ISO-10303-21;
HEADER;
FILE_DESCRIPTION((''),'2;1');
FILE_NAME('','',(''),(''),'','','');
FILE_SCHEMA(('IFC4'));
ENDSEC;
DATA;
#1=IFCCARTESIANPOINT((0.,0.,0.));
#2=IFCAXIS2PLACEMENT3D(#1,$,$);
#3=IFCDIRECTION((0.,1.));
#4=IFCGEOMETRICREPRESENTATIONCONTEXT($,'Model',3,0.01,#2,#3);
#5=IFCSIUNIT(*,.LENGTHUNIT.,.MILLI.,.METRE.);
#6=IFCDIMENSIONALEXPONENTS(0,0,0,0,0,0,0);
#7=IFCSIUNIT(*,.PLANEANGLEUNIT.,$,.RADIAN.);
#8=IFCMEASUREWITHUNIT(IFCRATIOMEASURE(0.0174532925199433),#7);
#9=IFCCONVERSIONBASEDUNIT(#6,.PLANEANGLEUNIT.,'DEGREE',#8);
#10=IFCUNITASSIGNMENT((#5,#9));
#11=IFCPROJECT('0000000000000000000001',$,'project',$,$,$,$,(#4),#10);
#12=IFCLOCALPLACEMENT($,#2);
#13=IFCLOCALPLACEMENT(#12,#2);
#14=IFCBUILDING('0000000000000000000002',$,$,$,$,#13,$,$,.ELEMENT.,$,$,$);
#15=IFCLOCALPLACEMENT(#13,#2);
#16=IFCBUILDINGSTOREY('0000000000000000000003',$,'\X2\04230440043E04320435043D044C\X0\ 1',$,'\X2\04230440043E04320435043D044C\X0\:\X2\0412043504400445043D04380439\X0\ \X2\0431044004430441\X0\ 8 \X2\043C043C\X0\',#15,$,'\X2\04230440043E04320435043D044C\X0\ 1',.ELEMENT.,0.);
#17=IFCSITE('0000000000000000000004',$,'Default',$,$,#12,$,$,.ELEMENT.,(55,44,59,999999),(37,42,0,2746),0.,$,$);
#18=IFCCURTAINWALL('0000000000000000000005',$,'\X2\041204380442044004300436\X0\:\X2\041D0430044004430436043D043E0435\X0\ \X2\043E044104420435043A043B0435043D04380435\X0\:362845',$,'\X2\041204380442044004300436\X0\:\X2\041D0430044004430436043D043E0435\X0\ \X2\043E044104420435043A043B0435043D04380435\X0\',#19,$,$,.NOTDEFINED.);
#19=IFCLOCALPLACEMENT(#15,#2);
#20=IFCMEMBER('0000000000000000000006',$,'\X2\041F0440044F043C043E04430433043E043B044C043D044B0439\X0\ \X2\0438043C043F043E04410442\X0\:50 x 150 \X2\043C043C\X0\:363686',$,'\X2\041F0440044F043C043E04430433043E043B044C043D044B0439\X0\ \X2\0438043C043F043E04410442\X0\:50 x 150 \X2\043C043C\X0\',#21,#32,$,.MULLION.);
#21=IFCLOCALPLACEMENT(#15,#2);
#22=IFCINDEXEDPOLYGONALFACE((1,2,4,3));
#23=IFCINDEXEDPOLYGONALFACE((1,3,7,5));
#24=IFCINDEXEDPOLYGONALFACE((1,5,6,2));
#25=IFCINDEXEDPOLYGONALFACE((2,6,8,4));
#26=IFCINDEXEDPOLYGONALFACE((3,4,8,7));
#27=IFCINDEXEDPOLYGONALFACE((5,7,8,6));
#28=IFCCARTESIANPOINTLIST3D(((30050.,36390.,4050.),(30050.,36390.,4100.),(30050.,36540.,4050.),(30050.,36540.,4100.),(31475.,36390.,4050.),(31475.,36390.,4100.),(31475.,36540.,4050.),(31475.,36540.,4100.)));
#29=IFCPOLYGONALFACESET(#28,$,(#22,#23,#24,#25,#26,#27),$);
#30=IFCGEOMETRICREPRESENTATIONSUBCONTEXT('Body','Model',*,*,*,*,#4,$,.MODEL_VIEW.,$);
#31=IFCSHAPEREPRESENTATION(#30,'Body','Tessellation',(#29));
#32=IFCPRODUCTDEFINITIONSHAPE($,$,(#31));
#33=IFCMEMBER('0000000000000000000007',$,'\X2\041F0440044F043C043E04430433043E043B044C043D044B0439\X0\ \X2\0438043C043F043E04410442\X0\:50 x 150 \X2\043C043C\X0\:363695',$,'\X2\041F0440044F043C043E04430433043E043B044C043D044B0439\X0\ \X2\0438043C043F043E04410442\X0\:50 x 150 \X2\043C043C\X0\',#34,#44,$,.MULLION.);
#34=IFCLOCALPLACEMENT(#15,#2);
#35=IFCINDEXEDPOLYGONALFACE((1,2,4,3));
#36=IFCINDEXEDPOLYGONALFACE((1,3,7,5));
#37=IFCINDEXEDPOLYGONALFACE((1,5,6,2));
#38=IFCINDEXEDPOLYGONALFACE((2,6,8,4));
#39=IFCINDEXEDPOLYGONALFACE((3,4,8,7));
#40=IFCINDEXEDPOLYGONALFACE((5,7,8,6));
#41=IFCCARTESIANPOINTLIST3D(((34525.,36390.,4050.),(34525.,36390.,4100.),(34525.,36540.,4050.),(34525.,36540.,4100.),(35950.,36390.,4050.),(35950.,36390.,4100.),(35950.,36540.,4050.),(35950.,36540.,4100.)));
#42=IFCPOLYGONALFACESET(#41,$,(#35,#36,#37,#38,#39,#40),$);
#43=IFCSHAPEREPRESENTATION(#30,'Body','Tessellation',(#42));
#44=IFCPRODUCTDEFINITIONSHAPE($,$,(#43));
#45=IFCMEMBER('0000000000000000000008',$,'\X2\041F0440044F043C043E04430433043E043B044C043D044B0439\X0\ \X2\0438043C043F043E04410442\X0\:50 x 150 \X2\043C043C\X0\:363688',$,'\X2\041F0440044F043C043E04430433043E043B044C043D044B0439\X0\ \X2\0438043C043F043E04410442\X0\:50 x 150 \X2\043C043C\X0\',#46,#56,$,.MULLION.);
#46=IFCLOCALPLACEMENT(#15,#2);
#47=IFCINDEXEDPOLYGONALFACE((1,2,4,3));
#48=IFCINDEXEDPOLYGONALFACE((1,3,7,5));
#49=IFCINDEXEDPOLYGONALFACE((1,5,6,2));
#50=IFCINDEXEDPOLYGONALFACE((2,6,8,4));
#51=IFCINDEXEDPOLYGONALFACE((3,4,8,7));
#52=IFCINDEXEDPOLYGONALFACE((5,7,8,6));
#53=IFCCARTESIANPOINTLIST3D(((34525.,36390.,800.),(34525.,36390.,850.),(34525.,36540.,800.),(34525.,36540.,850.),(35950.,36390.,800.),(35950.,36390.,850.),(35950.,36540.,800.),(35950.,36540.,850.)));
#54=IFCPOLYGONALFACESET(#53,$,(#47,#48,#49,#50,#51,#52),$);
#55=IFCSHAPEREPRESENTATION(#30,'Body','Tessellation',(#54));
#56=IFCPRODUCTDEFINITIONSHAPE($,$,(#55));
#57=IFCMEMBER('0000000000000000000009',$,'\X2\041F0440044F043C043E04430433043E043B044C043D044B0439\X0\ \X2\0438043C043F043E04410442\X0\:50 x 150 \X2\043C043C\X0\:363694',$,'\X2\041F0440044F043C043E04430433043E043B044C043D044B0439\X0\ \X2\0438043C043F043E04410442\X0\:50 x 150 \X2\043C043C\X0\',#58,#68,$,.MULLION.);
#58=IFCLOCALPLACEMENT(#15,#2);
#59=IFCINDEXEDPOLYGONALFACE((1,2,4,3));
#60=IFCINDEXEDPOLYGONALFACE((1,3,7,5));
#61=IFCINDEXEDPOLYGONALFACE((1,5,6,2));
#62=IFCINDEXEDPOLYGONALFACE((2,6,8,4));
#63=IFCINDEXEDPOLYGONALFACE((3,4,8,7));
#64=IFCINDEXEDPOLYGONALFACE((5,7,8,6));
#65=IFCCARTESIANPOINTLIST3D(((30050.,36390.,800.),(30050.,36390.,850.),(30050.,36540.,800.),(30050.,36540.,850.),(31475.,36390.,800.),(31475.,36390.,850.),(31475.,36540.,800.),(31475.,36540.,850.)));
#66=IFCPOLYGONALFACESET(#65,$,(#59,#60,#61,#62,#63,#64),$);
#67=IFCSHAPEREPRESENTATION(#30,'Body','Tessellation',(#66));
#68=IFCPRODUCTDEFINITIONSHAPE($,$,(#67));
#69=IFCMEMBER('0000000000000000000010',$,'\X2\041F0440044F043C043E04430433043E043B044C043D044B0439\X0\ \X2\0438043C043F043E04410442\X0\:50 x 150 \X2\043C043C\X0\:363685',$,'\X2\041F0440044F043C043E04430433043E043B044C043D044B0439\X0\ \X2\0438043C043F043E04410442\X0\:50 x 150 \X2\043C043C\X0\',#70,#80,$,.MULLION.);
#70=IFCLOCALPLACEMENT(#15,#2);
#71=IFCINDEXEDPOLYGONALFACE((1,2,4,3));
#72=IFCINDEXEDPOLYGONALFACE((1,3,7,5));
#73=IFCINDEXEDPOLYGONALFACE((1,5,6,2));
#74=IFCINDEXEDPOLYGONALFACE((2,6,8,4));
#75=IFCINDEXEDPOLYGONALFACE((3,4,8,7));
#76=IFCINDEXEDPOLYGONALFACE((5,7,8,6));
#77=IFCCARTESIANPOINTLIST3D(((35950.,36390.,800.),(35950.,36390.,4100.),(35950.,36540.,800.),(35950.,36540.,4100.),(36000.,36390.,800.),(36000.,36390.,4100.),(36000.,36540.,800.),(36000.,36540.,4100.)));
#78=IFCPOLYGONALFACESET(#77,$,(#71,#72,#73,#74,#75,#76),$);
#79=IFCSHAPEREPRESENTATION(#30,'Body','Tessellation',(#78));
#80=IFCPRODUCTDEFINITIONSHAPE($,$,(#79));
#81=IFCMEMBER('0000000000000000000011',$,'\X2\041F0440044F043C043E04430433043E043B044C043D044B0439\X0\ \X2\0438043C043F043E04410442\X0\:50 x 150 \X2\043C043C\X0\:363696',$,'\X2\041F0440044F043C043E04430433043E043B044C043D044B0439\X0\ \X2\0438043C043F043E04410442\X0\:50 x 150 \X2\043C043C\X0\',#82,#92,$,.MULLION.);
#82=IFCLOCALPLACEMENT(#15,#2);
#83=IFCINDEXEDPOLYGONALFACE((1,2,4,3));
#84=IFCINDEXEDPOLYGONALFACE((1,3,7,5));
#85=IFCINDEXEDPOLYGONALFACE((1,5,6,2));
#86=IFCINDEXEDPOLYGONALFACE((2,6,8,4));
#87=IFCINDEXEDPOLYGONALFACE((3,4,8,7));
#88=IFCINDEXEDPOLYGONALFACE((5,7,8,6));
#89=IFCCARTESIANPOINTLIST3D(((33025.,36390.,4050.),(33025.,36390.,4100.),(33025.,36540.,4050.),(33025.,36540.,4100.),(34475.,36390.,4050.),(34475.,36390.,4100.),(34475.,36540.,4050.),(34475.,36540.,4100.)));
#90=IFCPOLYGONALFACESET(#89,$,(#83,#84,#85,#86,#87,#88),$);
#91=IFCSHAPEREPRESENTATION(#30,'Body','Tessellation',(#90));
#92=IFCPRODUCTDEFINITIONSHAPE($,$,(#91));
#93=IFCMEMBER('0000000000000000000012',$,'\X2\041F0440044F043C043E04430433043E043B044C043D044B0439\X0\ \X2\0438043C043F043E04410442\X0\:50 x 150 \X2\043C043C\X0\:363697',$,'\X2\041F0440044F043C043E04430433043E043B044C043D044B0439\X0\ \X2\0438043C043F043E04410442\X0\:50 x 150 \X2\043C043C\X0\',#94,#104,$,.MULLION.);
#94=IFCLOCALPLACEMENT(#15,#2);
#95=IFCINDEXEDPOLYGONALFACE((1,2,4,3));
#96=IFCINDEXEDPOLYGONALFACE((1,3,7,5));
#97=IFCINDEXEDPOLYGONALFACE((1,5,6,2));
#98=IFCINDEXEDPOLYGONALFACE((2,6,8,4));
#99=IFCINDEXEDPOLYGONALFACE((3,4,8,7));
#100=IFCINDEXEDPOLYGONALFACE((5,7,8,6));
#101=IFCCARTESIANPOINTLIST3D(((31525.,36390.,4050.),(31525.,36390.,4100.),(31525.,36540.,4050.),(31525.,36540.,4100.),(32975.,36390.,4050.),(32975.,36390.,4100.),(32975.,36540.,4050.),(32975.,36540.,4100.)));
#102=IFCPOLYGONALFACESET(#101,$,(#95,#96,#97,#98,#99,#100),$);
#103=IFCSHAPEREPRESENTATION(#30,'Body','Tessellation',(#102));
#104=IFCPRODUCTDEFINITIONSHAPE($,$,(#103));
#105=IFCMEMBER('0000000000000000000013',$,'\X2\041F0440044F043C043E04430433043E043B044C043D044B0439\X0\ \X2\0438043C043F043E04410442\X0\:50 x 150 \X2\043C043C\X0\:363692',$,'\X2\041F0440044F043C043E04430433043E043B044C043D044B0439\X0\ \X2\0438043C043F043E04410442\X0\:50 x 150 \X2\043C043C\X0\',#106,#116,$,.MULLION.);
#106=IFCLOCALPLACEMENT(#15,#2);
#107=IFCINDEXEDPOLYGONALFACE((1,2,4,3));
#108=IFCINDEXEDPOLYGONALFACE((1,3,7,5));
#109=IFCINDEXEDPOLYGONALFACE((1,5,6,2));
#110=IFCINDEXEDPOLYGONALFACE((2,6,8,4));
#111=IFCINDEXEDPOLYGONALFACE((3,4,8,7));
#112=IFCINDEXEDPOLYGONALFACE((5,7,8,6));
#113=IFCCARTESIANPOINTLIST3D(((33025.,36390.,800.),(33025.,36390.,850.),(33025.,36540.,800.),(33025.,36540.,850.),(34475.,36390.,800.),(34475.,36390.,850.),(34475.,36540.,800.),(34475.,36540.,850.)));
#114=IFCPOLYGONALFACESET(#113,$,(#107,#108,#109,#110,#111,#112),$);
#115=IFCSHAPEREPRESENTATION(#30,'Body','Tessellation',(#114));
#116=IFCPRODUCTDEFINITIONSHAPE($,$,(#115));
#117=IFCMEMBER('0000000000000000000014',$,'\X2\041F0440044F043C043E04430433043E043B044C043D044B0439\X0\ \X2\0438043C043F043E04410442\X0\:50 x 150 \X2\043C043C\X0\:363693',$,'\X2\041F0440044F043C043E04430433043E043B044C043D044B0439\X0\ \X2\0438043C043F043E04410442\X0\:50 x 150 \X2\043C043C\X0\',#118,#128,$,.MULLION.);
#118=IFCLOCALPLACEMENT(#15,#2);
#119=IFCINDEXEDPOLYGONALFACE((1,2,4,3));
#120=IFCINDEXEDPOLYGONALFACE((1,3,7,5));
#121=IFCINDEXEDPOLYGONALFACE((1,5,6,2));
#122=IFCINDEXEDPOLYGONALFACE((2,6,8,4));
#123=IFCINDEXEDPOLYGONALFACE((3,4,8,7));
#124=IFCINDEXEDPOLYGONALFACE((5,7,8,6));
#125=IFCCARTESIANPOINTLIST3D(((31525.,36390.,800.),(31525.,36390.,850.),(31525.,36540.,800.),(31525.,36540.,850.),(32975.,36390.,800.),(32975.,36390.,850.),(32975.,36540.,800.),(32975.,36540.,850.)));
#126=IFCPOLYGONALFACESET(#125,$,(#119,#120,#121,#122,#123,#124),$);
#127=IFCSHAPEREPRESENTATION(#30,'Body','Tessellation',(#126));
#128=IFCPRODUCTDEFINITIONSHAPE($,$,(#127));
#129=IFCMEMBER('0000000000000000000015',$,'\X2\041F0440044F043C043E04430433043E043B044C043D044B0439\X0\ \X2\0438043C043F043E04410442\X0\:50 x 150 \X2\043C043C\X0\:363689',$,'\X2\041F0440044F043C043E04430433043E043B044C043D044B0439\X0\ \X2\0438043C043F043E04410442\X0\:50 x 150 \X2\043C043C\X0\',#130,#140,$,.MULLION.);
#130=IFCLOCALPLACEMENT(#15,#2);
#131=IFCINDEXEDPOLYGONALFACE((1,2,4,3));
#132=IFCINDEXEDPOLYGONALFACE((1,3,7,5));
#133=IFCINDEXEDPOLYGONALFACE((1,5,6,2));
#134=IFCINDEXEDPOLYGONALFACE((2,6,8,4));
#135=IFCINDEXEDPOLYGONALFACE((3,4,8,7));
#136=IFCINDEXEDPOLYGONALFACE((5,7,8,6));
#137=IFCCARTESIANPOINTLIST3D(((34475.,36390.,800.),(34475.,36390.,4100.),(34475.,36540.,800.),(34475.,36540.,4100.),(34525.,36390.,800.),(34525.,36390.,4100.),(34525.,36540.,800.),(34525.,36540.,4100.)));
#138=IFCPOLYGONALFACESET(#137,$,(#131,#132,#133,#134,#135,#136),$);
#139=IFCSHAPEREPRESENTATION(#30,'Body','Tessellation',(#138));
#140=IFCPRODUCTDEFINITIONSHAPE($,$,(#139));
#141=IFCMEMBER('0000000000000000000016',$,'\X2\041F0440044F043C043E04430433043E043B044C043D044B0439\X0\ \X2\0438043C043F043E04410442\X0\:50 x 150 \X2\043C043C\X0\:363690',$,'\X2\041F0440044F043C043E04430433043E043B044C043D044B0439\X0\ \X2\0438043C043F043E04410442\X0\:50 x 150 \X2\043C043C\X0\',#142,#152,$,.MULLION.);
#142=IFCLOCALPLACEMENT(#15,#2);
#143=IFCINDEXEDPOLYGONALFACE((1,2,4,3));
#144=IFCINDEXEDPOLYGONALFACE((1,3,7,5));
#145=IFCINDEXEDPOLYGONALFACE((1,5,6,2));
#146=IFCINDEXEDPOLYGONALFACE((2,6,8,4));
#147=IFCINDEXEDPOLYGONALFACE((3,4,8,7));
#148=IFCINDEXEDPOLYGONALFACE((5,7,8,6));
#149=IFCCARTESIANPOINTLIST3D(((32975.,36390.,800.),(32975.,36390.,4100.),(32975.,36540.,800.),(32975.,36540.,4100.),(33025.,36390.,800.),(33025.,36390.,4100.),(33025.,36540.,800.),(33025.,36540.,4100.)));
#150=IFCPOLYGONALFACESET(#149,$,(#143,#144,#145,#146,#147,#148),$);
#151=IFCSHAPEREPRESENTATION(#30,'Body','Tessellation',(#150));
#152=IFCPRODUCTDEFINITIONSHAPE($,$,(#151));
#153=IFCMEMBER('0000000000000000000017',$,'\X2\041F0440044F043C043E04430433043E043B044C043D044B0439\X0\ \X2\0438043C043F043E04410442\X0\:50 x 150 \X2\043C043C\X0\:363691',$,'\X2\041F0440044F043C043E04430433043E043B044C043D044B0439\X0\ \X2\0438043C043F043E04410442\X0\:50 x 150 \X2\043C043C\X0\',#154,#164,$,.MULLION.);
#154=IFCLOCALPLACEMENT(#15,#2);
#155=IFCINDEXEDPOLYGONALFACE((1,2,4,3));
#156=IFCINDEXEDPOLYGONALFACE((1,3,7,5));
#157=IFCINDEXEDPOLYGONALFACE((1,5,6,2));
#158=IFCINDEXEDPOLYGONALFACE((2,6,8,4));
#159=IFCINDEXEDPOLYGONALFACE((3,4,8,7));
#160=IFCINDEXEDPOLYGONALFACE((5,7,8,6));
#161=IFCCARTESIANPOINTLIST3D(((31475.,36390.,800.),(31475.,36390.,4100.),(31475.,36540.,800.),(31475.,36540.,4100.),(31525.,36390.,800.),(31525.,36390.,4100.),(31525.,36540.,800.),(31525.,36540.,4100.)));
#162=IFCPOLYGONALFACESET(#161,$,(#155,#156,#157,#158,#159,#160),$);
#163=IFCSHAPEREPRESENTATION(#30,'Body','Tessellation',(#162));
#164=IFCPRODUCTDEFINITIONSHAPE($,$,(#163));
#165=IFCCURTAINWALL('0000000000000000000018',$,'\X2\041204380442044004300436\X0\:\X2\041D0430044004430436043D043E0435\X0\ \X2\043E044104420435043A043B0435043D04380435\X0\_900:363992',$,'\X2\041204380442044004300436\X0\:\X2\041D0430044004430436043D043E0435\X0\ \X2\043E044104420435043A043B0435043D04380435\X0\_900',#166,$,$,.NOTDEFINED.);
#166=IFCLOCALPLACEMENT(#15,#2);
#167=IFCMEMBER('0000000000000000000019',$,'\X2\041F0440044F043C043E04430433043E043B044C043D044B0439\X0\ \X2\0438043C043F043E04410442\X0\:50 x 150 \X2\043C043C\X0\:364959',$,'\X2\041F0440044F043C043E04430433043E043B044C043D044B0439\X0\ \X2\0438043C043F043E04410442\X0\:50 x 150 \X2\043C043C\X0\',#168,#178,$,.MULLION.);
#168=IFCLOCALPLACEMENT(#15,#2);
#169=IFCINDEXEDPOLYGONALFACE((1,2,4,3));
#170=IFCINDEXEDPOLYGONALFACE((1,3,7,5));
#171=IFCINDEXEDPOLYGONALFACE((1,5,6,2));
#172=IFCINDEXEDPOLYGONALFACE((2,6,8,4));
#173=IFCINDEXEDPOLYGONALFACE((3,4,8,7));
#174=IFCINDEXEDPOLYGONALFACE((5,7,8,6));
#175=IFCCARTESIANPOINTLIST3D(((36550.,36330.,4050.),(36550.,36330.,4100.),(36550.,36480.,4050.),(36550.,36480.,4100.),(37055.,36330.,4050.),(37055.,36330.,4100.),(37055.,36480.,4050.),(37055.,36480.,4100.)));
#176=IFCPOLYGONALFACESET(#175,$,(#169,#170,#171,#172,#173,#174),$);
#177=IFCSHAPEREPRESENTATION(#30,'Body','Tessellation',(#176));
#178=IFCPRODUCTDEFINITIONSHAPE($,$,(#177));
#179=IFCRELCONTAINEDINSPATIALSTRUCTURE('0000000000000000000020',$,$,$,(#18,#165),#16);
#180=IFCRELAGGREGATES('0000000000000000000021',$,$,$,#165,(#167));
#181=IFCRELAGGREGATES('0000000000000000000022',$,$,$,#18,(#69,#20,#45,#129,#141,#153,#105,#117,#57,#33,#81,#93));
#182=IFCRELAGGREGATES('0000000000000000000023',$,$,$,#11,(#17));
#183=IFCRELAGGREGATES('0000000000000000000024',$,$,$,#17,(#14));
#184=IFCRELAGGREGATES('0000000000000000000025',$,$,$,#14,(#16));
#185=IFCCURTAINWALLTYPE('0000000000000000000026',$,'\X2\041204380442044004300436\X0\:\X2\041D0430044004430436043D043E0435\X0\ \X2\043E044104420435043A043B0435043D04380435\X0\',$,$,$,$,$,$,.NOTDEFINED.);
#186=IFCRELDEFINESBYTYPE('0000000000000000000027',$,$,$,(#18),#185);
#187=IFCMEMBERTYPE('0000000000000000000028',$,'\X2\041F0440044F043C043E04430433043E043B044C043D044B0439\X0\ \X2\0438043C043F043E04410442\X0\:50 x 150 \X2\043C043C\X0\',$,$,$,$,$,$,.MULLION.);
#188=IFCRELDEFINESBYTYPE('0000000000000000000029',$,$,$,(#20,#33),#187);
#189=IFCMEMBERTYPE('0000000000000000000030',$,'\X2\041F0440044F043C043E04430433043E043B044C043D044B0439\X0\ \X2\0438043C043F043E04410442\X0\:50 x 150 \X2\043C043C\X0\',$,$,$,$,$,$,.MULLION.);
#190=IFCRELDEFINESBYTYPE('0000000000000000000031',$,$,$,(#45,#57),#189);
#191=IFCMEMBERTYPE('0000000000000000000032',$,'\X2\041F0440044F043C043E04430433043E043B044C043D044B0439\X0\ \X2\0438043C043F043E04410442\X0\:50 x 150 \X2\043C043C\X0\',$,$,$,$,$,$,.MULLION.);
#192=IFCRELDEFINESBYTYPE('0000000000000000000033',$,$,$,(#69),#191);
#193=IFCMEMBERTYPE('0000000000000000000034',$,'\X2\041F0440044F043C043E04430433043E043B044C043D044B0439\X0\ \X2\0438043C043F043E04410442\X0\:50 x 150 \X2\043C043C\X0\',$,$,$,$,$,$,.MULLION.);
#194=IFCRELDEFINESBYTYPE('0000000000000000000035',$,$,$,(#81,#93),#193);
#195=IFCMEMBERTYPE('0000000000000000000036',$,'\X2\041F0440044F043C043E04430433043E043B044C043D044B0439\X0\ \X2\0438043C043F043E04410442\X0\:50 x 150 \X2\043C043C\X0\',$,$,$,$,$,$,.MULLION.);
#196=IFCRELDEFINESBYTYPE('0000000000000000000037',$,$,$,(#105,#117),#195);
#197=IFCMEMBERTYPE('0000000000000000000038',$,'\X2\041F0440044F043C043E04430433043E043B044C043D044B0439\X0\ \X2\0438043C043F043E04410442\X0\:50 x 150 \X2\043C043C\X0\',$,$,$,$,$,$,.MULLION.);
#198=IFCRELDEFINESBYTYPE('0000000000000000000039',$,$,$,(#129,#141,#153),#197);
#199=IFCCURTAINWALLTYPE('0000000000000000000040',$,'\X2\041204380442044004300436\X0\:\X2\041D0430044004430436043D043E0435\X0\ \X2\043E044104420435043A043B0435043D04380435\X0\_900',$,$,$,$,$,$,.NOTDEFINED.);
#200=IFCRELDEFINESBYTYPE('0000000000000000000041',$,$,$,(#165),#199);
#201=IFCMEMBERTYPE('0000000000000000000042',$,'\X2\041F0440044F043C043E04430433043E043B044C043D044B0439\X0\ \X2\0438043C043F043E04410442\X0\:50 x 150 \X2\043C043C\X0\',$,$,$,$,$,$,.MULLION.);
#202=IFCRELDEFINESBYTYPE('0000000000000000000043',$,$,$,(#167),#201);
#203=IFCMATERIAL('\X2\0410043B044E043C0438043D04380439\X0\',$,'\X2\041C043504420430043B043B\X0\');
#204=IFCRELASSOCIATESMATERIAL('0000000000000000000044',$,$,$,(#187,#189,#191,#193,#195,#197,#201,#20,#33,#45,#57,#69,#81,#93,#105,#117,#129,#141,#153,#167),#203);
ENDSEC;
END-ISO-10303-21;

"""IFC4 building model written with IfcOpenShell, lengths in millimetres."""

from ifc_helpers import new_model, entity, si_unit, converted_unit, direction, frame, origin, origin_2d_with_axis, place, context, subcontext, project, spatial, rectangle, extrude, source, transform, mapped, material, material_profile, profile_set, profile_usage, type_object, type_shapes, element, aggregate, save


model = new_model("IFC4")

# Units and contexts
model_context = context("Model", 3, precision=0.01, world=origin(), true_north=direction((0.0, 1.0)))
body_context = subcontext(model_context, "Body", "Model", "MODEL_VIEW")
ifc_project = project(units=[si_unit("LENGTHUNIT", "METRE", prefix="MILLI"), converted_unit("PLANEANGLEUNIT", "DEGREE", entity("IfcRatioMeasure", 0.0174532925199433), si_unit("PLANEANGLEUNIT", "RADIAN"), dimensions=[0, 0, 0, 0, 0, 0, 0])], contexts=[model_context])

# Site, building, storey
site_placement = place(None, origin())
site = spatial("IfcSite", under=ifc_project, at=site_placement, Name="Default", CompositionType="ELEMENT", RefLatitude=(55, 44, 59, 999999), RefLongitude=(37, 42, 0, 2746), RefElevation=0.0)
building_placement = place(site_placement, origin())
building = spatial("IfcBuilding", under=site, at=building_placement, CompositionType="ELEMENT")
storey_placement = place(building_placement, origin())
storey = spatial("IfcBuildingStorey", under=building, at=storey_placement, Name="Уровень 1", ObjectType="Уровень:Верхний брус 8 мм", LongName="Уровень 1", CompositionType="ELEMENT", Elevation=0.0)

# Curtain walls, members
curtain_wall_type_1 = type_object("IfcCurtainWallType", Name="Витраж:Наружное остекление", PredefinedType="NOTDEFINED")
curtain_wall_1_placement = place(storey_placement, origin())
curtain_wall_1 = element("IfcCurtainWall", 1, at=curtain_wall_1_placement, inside=storey, type_object=curtain_wall_type_1, Name="Витраж:Наружное остекление:362845", ObjectType="Витраж:Наружное остекление", PredefinedType="NOTDEFINED")
ifc_material_1 = material(Name="Алюминий", Category="Металл")
ifc_material_profile = material_profile(ifc_material_1, rectangle(XDim=150.0, YDim=50.0, at=origin_2d_with_axis()), Name="50 x 150 мм")
ifc_profile_set = profile_set([ifc_material_profile], Name="50 x 150 мм")
ifc_profile_usage_1 = profile_usage(ifc_profile_set)
member_type_1 = type_object("IfcMemberType", Name="Прямоугольный импост:50 x 150 мм", PredefinedType="MULLION", material=ifc_profile_set)
shared_shape_1 = source(origin(), body_context, "Body", "SweptSolid", [
    extrude(rectangle(XDim=150.0, YDim=50.0, at=origin_2d_with_axis()), frame((-25.0, 0.0, -1425.0), z_axis=(0.0, 0.0, 1.0), x_axis=(0.0, -1.0, 0.0)), (0.0, 0.0, 1.0), 1425.0),
])
type_shapes(member_type_1, [shared_shape_1])
member_1_placement = place(storey_placement, frame((30050.0, 36465.0, 4100.0), z_axis=(-1.0, 0.0, 0.0), x_axis=(0.0, 0.0, 1.0)))
member_1 = element("IfcMember", 2, at=member_1_placement, type_object=member_type_1, material=ifc_profile_usage_1, Name="Прямоугольный импост:50 x 150 мм:363686", ObjectType="Прямоугольный импост:50 x 150 мм", PredefinedType="MULLION", context=body_context, shape_type="MappedRepresentation", body=[
    mapped(shared_shape_1, transform((0.0, 0.0, 0.0), scale=1.0)),
])
ifc_profile_usage_2 = profile_usage(ifc_profile_set)
member_2_placement = place(storey_placement, frame((34525.0, 36465.0, 4100.0), z_axis=(-1.0, 0.0, 0.0), x_axis=(0.0, 0.0, 1.0)))
member_2 = element("IfcMember", 3, at=member_2_placement, type_object=member_type_1, material=ifc_profile_usage_2, Name="Прямоугольный импост:50 x 150 мм:363695", ObjectType="Прямоугольный импост:50 x 150 мм", PredefinedType="MULLION", context=body_context, shape_type="MappedRepresentation", body=[
    mapped(shared_shape_1, transform((0.0, 0.0, 0.0), scale=1.0)),
])
ifc_profile_usage_3 = profile_usage(ifc_profile_set)
member_type_2 = type_object("IfcMemberType", Name="Прямоугольный импост:50 x 150 мм", PredefinedType="MULLION", material=ifc_profile_set)
shared_shape_2 = source(origin(), body_context, "Body", "SweptSolid", [
    extrude(rectangle(XDim=150.0, YDim=50.0, at=origin_2d_with_axis()), frame((-25.0, 0.0, -1425.0), z_axis=(0.0, 0.0, 1.0), x_axis=(0.0, -1.0, 0.0)), (0.0, 0.0, 1.0), 1425.0),
])
type_shapes(member_type_2, [shared_shape_2])
member_3_placement = place(storey_placement, frame((35950.0, 36465.0, 800.0), z_axis=(1.0, 0.0, 0.0), x_axis=(0.0, 0.0, -1.0)))
member_3 = element("IfcMember", 4, at=member_3_placement, type_object=member_type_2, material=ifc_profile_usage_3, Name="Прямоугольный импост:50 x 150 мм:363688", ObjectType="Прямоугольный импост:50 x 150 мм", PredefinedType="MULLION", context=body_context, shape_type="MappedRepresentation", body=[
    mapped(shared_shape_2, transform((0.0, 0.0, 0.0), scale=1.0)),
])
ifc_profile_usage_4 = profile_usage(ifc_profile_set)
member_4_placement = place(storey_placement, frame((31475.0, 36465.0, 800.0), z_axis=(1.0, 0.0, 0.0), x_axis=(0.0, 0.0, -1.0)))
member_4 = element("IfcMember", 5, at=member_4_placement, type_object=member_type_2, material=ifc_profile_usage_4, Name="Прямоугольный импост:50 x 150 мм:363694", ObjectType="Прямоугольный импост:50 x 150 мм", PredefinedType="MULLION", context=body_context, shape_type="MappedRepresentation", body=[
    mapped(shared_shape_2, transform((0.0, 0.0, 0.0), scale=1.0)),
])
ifc_profile_usage_5 = profile_usage(ifc_profile_set)
member_type_3 = type_object("IfcMemberType", Name="Прямоугольный импост:50 x 150 мм", PredefinedType="MULLION", material=ifc_profile_set)
shared_shape_3 = source(origin(), body_context, "Body", "SweptSolid", [
    extrude(rectangle(XDim=150.0, YDim=50.0, at=origin_2d_with_axis()), frame((-25.0, 0.0, -3300.0), z_axis=(0.0, 0.0, 1.0), x_axis=(0.0, -1.0, 0.0)), (0.0, 0.0, 1.0), 3300.0),
])
type_shapes(member_type_3, [shared_shape_3])
member_5_placement = place(storey_placement, frame((36000.0, 36465.0, 4100.0)))
member_5 = element("IfcMember", 6, at=member_5_placement, type_object=member_type_3, material=ifc_profile_usage_5, Name="Прямоугольный импост:50 x 150 мм:363685", ObjectType="Прямоугольный импост:50 x 150 мм", PredefinedType="MULLION", context=body_context, shape_type="MappedRepresentation", body=[
    mapped(shared_shape_3, transform((0.0, 0.0, 0.0), scale=1.0)),
])
ifc_profile_usage_6 = profile_usage(ifc_profile_set)
member_type_4 = type_object("IfcMemberType", Name="Прямоугольный импост:50 x 150 мм", PredefinedType="MULLION", material=ifc_profile_set)
shared_shape_4 = source(origin(), body_context, "Body", "SweptSolid", [
    extrude(rectangle(XDim=150.0, YDim=50.0, at=origin_2d_with_axis()), frame((-25.0, 0.0, -1450.0), z_axis=(0.0, 0.0, 1.0), x_axis=(0.0, -1.0, 0.0)), (0.0, 0.0, 1.0), 1450.0),
])
type_shapes(member_type_4, [shared_shape_4])
member_6_placement = place(storey_placement, frame((33025.0, 36465.0, 4100.0), z_axis=(-1.0, 0.0, 0.0), x_axis=(0.0, 0.0, 1.0)))
member_6 = element("IfcMember", 7, at=member_6_placement, type_object=member_type_4, material=ifc_profile_usage_6, Name="Прямоугольный импост:50 x 150 мм:363696", ObjectType="Прямоугольный импост:50 x 150 мм", PredefinedType="MULLION", context=body_context, shape_type="MappedRepresentation", body=[
    mapped(shared_shape_4, transform((0.0, 0.0, 0.0), scale=1.0)),
])
ifc_profile_usage_7 = profile_usage(ifc_profile_set)
member_7_placement = place(storey_placement, frame((31525.0, 36465.0, 4100.0), z_axis=(-1.0, 0.0, 0.0), x_axis=(0.0, 0.0, 1.0)))
member_7 = element("IfcMember", 8, at=member_7_placement, type_object=member_type_4, material=ifc_profile_usage_7, Name="Прямоугольный импост:50 x 150 мм:363697", ObjectType="Прямоугольный импост:50 x 150 мм", PredefinedType="MULLION", context=body_context, shape_type="MappedRepresentation", body=[
    mapped(shared_shape_4, transform((0.0, 0.0, 0.0), scale=1.0)),
])
ifc_profile_usage_8 = profile_usage(ifc_profile_set)
member_type_5 = type_object("IfcMemberType", Name="Прямоугольный импост:50 x 150 мм", PredefinedType="MULLION", material=ifc_profile_set)
shared_shape_5 = source(origin(), body_context, "Body", "SweptSolid", [
    extrude(rectangle(XDim=150.0, YDim=50.0, at=origin_2d_with_axis()), frame((-25.0, 0.0, -1450.0), z_axis=(0.0, 0.0, 1.0), x_axis=(0.0, -1.0, 0.0)), (0.0, 0.0, 1.0), 1450.0),
])
type_shapes(member_type_5, [shared_shape_5])
member_8_placement = place(storey_placement, frame((34475.0, 36465.0, 800.0), z_axis=(1.0, 0.0, 0.0), x_axis=(0.0, 0.0, -1.0)))
member_8 = element("IfcMember", 9, at=member_8_placement, type_object=member_type_5, material=ifc_profile_usage_8, Name="Прямоугольный импост:50 x 150 мм:363692", ObjectType="Прямоугольный импост:50 x 150 мм", PredefinedType="MULLION", context=body_context, shape_type="MappedRepresentation", body=[
    mapped(shared_shape_5, transform((0.0, 0.0, 0.0), scale=1.0)),
])
ifc_profile_usage_9 = profile_usage(ifc_profile_set)
member_9_placement = place(storey_placement, frame((32975.0, 36465.0, 800.0), z_axis=(1.0, 0.0, 0.0), x_axis=(0.0, 0.0, -1.0)))
member_9 = element("IfcMember", 10, at=member_9_placement, type_object=member_type_5, material=ifc_profile_usage_9, Name="Прямоугольный импост:50 x 150 мм:363693", ObjectType="Прямоугольный импост:50 x 150 мм", PredefinedType="MULLION", context=body_context, shape_type="MappedRepresentation", body=[
    mapped(shared_shape_5, transform((0.0, 0.0, 0.0), scale=1.0)),
])
ifc_profile_usage_10 = profile_usage(ifc_profile_set)
member_type_6 = type_object("IfcMemberType", Name="Прямоугольный импост:50 x 150 мм", PredefinedType="MULLION", material=ifc_profile_set)
shared_shape_6 = source(origin(), body_context, "Body", "SweptSolid", [
    extrude(rectangle(XDim=150.0, YDim=50.0, at=origin_2d_with_axis()), frame((0.0, 0.0, -3300.0), z_axis=(0.0, 0.0, 1.0), x_axis=(0.0, -1.0, 0.0)), (0.0, 0.0, 1.0), 3300.0),
])
type_shapes(member_type_6, [shared_shape_6])
member_10_placement = place(storey_placement, frame((34500.0, 36465.0, 800.0), z_axis=(0.0, 0.0, -1.0), x_axis=(-1.0, 0.0, 0.0)))
member_10 = element("IfcMember", 11, at=member_10_placement, type_object=member_type_6, material=ifc_profile_usage_10, Name="Прямоугольный импост:50 x 150 мм:363689", ObjectType="Прямоугольный импост:50 x 150 мм", PredefinedType="MULLION", context=body_context, shape_type="MappedRepresentation", body=[
    mapped(shared_shape_6, transform((0.0, 0.0, 0.0), scale=1.0)),
])
ifc_profile_usage_11 = profile_usage(ifc_profile_set)
member_11_placement = place(storey_placement, frame((33000.0, 36465.0, 800.0), z_axis=(0.0, 0.0, -1.0), x_axis=(-1.0, 0.0, 0.0)))
member_11 = element("IfcMember", 12, at=member_11_placement, type_object=member_type_6, material=ifc_profile_usage_11, Name="Прямоугольный импост:50 x 150 мм:363690", ObjectType="Прямоугольный импост:50 x 150 мм", PredefinedType="MULLION", context=body_context, shape_type="MappedRepresentation", body=[
    mapped(shared_shape_6, transform((0.0, 0.0, 0.0), scale=1.0)),
])
ifc_profile_usage_12 = profile_usage(ifc_profile_set)
member_12_placement = place(storey_placement, frame((31500.0, 36465.0, 800.0), z_axis=(0.0, 0.0, -1.0), x_axis=(-1.0, 0.0, 0.0)))
member_12 = element("IfcMember", 13, at=member_12_placement, type_object=member_type_6, material=ifc_profile_usage_12, Name="Прямоугольный импост:50 x 150 мм:363691", ObjectType="Прямоугольный импост:50 x 150 мм", PredefinedType="MULLION", context=body_context, shape_type="MappedRepresentation", body=[
    mapped(shared_shape_6, transform((0.0, 0.0, 0.0), scale=1.0)),
])
curtain_wall_type_2 = type_object("IfcCurtainWallType", Name="Витраж:Наружное остекление_900", PredefinedType="NOTDEFINED")
curtain_wall_2_placement = place(storey_placement, origin())
curtain_wall_2 = element("IfcCurtainWall", 14, at=curtain_wall_2_placement, inside=storey, type_object=curtain_wall_type_2, Name="Витраж:Наружное остекление_900:363992", ObjectType="Витраж:Наружное остекление_900", PredefinedType="NOTDEFINED")
ifc_profile_usage_13 = profile_usage(ifc_profile_set)
member_type_7 = type_object("IfcMemberType", Name="Прямоугольный импост:50 x 150 мм", PredefinedType="MULLION", material=ifc_profile_set)
shared_shape_7 = source(origin(), body_context, "Body", "SweptSolid", [
    extrude(rectangle(XDim=150.0, YDim=50.0, at=origin_2d_with_axis()), frame((-25.0, 0.0, -505.0), z_axis=(0.0, 0.0, 1.0), x_axis=(0.0, -1.0, 0.0)), (0.0, 0.0, 1.0), 505.0),
])
type_shapes(member_type_7, [shared_shape_7])
member_13_placement = place(storey_placement, frame((36550.0, 36405.0, 4100.0), z_axis=(-1.0, 0.0, 0.0), x_axis=(0.0, 0.0, 1.0)))
member_13 = element("IfcMember", 15, at=member_13_placement, type_object=member_type_7, material=ifc_profile_usage_13, Name="Прямоугольный импост:50 x 150 мм:364959", ObjectType="Прямоугольный импост:50 x 150 мм", PredefinedType="MULLION", context=body_context, shape_type="MappedRepresentation", body=[
    mapped(shared_shape_7, transform((0.0, 0.0, 0.0), scale=1.0)),
])
aggregate(curtain_wall_2, [member_13])

aggregate(curtain_wall_1, [member_5, member_1, member_3, member_10, member_11, member_12, member_8, member_9, member_4, member_2, member_6, member_7])

save(model, "model.ifc")
